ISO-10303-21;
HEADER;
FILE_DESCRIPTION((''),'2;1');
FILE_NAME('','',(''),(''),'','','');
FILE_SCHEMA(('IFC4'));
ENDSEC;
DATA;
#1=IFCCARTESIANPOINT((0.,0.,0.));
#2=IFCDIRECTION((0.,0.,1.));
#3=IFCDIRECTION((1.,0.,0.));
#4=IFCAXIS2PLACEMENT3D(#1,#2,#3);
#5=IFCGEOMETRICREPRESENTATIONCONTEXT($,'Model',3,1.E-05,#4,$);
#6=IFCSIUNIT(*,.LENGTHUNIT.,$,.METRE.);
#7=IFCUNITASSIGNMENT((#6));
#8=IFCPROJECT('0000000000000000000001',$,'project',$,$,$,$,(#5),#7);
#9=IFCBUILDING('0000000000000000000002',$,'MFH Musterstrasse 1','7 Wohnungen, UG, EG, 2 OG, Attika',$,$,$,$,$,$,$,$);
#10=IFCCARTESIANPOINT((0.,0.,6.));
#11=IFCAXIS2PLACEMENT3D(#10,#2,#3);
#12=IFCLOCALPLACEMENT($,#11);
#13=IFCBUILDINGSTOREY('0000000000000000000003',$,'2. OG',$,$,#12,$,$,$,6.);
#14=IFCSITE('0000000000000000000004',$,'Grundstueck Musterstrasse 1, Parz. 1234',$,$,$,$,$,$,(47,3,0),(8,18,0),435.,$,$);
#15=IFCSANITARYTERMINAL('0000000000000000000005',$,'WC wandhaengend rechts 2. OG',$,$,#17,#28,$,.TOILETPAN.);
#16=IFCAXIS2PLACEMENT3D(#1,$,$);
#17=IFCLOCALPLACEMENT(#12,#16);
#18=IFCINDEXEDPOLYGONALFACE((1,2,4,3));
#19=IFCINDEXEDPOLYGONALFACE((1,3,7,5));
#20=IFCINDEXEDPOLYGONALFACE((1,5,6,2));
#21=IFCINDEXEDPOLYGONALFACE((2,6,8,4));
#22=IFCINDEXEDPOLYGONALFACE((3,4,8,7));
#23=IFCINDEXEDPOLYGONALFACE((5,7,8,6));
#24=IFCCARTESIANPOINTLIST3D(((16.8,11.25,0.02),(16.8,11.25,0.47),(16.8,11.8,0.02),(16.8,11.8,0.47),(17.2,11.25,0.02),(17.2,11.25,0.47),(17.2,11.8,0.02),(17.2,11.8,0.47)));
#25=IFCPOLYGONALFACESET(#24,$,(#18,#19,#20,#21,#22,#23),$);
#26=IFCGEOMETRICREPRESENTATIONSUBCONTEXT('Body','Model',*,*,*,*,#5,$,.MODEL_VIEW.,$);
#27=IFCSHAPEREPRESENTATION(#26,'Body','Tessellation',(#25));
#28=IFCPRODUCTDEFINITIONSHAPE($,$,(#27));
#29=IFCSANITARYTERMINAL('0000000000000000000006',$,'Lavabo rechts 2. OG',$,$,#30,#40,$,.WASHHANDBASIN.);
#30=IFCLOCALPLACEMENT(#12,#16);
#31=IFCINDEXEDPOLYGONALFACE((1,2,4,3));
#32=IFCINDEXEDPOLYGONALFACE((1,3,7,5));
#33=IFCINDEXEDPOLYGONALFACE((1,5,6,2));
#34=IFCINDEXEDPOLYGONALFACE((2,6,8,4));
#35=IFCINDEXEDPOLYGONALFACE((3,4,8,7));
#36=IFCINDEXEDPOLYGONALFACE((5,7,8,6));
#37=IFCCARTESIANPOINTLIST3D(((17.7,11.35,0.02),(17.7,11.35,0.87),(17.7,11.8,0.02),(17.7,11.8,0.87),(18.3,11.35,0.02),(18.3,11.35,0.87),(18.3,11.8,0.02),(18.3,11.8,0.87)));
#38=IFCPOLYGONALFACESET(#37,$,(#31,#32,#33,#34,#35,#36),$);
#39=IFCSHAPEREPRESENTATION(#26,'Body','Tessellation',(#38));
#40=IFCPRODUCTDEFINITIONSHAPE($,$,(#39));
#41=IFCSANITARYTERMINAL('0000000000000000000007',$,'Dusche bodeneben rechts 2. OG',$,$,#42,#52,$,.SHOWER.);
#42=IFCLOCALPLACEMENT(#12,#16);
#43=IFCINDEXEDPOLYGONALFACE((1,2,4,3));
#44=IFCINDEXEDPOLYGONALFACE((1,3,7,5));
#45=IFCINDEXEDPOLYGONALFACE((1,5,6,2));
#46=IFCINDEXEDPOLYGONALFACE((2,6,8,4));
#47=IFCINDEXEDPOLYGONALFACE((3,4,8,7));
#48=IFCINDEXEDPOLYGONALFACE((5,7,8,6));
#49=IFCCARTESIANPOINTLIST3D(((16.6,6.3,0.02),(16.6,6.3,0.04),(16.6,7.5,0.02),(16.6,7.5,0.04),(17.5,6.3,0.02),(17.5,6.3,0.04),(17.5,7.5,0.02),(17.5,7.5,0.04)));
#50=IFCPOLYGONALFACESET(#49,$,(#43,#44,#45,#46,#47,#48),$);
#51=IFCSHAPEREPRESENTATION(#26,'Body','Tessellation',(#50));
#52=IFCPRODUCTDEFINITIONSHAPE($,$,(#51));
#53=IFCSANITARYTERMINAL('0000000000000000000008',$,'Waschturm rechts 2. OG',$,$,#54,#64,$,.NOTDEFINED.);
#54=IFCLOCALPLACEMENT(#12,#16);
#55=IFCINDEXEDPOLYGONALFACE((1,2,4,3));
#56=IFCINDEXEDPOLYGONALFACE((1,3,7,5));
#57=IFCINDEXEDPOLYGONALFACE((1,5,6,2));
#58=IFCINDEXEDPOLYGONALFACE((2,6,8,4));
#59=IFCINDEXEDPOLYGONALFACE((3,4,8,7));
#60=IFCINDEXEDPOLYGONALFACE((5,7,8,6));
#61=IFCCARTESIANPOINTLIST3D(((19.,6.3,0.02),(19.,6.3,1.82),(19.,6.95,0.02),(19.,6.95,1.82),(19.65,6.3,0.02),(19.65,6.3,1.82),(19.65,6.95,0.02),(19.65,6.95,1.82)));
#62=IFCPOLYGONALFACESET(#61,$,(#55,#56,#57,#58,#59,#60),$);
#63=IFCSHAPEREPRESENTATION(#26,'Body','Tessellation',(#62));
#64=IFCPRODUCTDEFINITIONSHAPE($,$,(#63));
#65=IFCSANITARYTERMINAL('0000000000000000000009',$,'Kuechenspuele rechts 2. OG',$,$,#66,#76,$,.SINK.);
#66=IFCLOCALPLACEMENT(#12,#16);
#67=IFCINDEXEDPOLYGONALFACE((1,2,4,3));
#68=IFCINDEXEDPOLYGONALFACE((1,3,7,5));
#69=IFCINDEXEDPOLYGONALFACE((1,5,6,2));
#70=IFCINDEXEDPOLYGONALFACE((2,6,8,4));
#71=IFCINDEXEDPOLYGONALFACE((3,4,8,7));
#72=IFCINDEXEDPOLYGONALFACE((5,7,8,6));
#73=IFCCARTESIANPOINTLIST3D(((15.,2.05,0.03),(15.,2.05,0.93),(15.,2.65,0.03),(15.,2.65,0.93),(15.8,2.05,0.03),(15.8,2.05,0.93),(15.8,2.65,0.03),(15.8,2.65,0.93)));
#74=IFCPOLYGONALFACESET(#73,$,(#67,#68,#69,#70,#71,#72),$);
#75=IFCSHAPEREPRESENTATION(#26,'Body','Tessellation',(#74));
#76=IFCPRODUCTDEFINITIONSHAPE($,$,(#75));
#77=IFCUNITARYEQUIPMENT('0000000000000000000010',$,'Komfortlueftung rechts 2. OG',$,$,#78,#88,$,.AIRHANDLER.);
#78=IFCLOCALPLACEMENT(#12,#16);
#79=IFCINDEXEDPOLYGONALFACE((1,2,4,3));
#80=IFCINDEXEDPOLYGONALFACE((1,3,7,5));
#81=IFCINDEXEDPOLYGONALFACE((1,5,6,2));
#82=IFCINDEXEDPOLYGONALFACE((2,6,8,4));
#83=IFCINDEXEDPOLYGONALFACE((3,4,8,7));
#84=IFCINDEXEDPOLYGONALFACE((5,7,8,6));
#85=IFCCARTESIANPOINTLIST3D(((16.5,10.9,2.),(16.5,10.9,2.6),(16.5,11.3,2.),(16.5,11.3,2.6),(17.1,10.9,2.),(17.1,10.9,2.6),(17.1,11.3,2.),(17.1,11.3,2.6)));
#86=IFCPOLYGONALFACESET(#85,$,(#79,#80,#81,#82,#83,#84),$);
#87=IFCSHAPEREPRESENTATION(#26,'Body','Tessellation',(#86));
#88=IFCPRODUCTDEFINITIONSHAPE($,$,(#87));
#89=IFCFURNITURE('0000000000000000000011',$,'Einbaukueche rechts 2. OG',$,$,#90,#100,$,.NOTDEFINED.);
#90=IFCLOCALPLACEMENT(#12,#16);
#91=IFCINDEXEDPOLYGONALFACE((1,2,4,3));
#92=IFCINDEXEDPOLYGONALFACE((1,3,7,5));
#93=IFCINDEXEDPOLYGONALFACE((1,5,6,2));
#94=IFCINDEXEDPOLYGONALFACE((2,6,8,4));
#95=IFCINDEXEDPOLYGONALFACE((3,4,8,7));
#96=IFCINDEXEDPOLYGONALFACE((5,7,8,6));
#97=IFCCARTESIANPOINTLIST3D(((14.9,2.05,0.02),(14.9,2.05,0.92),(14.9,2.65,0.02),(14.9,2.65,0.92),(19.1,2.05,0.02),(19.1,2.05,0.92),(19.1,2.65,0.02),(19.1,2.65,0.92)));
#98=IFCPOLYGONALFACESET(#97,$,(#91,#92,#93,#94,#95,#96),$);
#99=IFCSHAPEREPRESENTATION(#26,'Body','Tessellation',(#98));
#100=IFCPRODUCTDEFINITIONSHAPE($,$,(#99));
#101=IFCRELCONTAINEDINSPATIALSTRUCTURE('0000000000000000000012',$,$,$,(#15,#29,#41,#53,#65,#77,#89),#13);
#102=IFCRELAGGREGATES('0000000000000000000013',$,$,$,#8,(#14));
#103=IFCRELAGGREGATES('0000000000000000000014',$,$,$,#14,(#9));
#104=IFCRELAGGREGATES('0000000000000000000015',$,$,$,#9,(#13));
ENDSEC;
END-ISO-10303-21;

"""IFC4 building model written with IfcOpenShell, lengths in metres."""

from ifc_helpers import new_model, si_unit, frame, frame_2d, origin_with_axes, place, context, subcontext, project, spatial, rectangle, extrude, element, save


model = new_model("IFC4")

# Units and contexts
model_context = context("Model", 3, precision=1e-05, world=origin_with_axes())
body_context = subcontext(model_context, "Body", "Model", "MODEL_VIEW")
ifc_project = project(units=[si_unit("LENGTHUNIT", "METRE")], contexts=[model_context])

# Site, building, storey
site = spatial("IfcSite", under=ifc_project, Name="Grundstueck Musterstrasse 1, Parz. 1234", RefLatitude=(47, 3, 0), RefLongitude=(8, 18, 0), RefElevation=435.0)
building = spatial("IfcBuilding", under=site, Name="MFH Musterstrasse 1", Description="7 Wohnungen, UG, EG, 2 OG, Attika")
storey_placement = place(None, frame((0.0, 0.0, 6.0), z_axis=(0.0, 0.0, 1.0), x_axis=(1.0, 0.0, 0.0)))
storey = spatial("IfcBuildingStorey", under=building, at=storey_placement, Name="2. OG", Elevation=6.0)

# Sanitary terminals
sanitary_terminal_1_placement = place(storey_placement, frame((16.8, 11.25, 0.02), z_axis=(0.0, 0.0, 1.0), x_axis=(1.0, 0.0, 0.0)))
element("IfcSanitaryTerminal", 1, at=sanitary_terminal_1_placement, inside=storey, Name="WC wandhaengend rechts 2. OG", PredefinedType="TOILETPAN", context=body_context, shape_type="SweptSolid", body=[
    extrude(rectangle(XDim=0.4, YDim=0.55, at=frame_2d((0.2, 0.275))), origin_with_axes(), (0.0, 0.0, 1.0), 0.45),
])
sanitary_terminal_2_placement = place(storey_placement, frame((17.7, 11.35, 0.02), z_axis=(0.0, 0.0, 1.0), x_axis=(1.0, 0.0, 0.0)))
element("IfcSanitaryTerminal", 2, at=sanitary_terminal_2_placement, inside=storey, Name="Lavabo rechts 2. OG", PredefinedType="WASHHANDBASIN", context=body_context, shape_type="SweptSolid", body=[
    extrude(rectangle(XDim=0.6, YDim=0.45, at=frame_2d((0.3, 0.225))), origin_with_axes(), (0.0, 0.0, 1.0), 0.85),
])
sanitary_terminal_3_placement = place(storey_placement, frame((16.6, 6.3, 0.02), z_axis=(0.0, 0.0, 1.0), x_axis=(1.0, 0.0, 0.0)))
element("IfcSanitaryTerminal", 3, at=sanitary_terminal_3_placement, inside=storey, Name="Dusche bodeneben rechts 2. OG", PredefinedType="SHOWER", context=body_context, shape_type="SweptSolid", body=[
    extrude(rectangle(XDim=0.9, YDim=1.2, at=frame_2d((0.45, 0.6))), origin_with_axes(), (0.0, 0.0, 1.0), 0.02),
])
sanitary_terminal_4_placement = place(storey_placement, frame((19.0, 6.3, 0.02), z_axis=(0.0, 0.0, 1.0), x_axis=(1.0, 0.0, 0.0)))
element("IfcSanitaryTerminal", 4, at=sanitary_terminal_4_placement, inside=storey, Name="Waschturm rechts 2. OG", PredefinedType="NOTDEFINED", context=body_context, shape_type="SweptSolid", body=[
    extrude(rectangle(XDim=0.65, YDim=0.65, at=frame_2d((0.325, 0.325))), origin_with_axes(), (0.0, 0.0, 1.0), 1.8),
])
sanitary_terminal_5_placement = place(storey_placement, frame((15.0, 2.05, 0.03), z_axis=(0.0, 0.0, 1.0), x_axis=(1.0, 0.0, 0.0)))
element("IfcSanitaryTerminal", 5, at=sanitary_terminal_5_placement, inside=storey, Name="Kuechenspuele rechts 2. OG", PredefinedType="SINK", context=body_context, shape_type="SweptSolid", body=[
    extrude(rectangle(XDim=0.8, YDim=0.6, at=frame_2d((0.4, 0.3))), origin_with_axes(), (0.0, 0.0, 1.0), 0.9),
])

# Unitary equipment
unitary_equipment_placement = place(storey_placement, frame((16.5, 10.9, 2.0), z_axis=(0.0, 0.0, 1.0), x_axis=(1.0, 0.0, 0.0)))
element("IfcUnitaryEquipment", 6, at=unitary_equipment_placement, inside=storey, Name="Komfortlueftung rechts 2. OG", PredefinedType="AIRHANDLER", context=body_context, shape_type="SweptSolid", body=[
    extrude(rectangle(XDim=0.6, YDim=0.4, at=frame_2d((0.3, 0.2))), origin_with_axes(), (0.0, 0.0, 1.0), 0.6),
])

# Furniture
furniture_placement = place(storey_placement, frame((14.9, 2.05, 0.02), z_axis=(0.0, 0.0, 1.0), x_axis=(1.0, 0.0, 0.0)))
element("IfcFurniture", 7, at=furniture_placement, inside=storey, Name="Einbaukueche rechts 2. OG", PredefinedType="NOTDEFINED", context=body_context, shape_type="SweptSolid", body=[
    extrude(rectangle(XDim=4.2, YDim=0.6, at=frame_2d((2.1, 0.3))), origin_with_axes(), (0.0, 0.0, 1.0), 0.9),
])

save(model, "model.ifc")
